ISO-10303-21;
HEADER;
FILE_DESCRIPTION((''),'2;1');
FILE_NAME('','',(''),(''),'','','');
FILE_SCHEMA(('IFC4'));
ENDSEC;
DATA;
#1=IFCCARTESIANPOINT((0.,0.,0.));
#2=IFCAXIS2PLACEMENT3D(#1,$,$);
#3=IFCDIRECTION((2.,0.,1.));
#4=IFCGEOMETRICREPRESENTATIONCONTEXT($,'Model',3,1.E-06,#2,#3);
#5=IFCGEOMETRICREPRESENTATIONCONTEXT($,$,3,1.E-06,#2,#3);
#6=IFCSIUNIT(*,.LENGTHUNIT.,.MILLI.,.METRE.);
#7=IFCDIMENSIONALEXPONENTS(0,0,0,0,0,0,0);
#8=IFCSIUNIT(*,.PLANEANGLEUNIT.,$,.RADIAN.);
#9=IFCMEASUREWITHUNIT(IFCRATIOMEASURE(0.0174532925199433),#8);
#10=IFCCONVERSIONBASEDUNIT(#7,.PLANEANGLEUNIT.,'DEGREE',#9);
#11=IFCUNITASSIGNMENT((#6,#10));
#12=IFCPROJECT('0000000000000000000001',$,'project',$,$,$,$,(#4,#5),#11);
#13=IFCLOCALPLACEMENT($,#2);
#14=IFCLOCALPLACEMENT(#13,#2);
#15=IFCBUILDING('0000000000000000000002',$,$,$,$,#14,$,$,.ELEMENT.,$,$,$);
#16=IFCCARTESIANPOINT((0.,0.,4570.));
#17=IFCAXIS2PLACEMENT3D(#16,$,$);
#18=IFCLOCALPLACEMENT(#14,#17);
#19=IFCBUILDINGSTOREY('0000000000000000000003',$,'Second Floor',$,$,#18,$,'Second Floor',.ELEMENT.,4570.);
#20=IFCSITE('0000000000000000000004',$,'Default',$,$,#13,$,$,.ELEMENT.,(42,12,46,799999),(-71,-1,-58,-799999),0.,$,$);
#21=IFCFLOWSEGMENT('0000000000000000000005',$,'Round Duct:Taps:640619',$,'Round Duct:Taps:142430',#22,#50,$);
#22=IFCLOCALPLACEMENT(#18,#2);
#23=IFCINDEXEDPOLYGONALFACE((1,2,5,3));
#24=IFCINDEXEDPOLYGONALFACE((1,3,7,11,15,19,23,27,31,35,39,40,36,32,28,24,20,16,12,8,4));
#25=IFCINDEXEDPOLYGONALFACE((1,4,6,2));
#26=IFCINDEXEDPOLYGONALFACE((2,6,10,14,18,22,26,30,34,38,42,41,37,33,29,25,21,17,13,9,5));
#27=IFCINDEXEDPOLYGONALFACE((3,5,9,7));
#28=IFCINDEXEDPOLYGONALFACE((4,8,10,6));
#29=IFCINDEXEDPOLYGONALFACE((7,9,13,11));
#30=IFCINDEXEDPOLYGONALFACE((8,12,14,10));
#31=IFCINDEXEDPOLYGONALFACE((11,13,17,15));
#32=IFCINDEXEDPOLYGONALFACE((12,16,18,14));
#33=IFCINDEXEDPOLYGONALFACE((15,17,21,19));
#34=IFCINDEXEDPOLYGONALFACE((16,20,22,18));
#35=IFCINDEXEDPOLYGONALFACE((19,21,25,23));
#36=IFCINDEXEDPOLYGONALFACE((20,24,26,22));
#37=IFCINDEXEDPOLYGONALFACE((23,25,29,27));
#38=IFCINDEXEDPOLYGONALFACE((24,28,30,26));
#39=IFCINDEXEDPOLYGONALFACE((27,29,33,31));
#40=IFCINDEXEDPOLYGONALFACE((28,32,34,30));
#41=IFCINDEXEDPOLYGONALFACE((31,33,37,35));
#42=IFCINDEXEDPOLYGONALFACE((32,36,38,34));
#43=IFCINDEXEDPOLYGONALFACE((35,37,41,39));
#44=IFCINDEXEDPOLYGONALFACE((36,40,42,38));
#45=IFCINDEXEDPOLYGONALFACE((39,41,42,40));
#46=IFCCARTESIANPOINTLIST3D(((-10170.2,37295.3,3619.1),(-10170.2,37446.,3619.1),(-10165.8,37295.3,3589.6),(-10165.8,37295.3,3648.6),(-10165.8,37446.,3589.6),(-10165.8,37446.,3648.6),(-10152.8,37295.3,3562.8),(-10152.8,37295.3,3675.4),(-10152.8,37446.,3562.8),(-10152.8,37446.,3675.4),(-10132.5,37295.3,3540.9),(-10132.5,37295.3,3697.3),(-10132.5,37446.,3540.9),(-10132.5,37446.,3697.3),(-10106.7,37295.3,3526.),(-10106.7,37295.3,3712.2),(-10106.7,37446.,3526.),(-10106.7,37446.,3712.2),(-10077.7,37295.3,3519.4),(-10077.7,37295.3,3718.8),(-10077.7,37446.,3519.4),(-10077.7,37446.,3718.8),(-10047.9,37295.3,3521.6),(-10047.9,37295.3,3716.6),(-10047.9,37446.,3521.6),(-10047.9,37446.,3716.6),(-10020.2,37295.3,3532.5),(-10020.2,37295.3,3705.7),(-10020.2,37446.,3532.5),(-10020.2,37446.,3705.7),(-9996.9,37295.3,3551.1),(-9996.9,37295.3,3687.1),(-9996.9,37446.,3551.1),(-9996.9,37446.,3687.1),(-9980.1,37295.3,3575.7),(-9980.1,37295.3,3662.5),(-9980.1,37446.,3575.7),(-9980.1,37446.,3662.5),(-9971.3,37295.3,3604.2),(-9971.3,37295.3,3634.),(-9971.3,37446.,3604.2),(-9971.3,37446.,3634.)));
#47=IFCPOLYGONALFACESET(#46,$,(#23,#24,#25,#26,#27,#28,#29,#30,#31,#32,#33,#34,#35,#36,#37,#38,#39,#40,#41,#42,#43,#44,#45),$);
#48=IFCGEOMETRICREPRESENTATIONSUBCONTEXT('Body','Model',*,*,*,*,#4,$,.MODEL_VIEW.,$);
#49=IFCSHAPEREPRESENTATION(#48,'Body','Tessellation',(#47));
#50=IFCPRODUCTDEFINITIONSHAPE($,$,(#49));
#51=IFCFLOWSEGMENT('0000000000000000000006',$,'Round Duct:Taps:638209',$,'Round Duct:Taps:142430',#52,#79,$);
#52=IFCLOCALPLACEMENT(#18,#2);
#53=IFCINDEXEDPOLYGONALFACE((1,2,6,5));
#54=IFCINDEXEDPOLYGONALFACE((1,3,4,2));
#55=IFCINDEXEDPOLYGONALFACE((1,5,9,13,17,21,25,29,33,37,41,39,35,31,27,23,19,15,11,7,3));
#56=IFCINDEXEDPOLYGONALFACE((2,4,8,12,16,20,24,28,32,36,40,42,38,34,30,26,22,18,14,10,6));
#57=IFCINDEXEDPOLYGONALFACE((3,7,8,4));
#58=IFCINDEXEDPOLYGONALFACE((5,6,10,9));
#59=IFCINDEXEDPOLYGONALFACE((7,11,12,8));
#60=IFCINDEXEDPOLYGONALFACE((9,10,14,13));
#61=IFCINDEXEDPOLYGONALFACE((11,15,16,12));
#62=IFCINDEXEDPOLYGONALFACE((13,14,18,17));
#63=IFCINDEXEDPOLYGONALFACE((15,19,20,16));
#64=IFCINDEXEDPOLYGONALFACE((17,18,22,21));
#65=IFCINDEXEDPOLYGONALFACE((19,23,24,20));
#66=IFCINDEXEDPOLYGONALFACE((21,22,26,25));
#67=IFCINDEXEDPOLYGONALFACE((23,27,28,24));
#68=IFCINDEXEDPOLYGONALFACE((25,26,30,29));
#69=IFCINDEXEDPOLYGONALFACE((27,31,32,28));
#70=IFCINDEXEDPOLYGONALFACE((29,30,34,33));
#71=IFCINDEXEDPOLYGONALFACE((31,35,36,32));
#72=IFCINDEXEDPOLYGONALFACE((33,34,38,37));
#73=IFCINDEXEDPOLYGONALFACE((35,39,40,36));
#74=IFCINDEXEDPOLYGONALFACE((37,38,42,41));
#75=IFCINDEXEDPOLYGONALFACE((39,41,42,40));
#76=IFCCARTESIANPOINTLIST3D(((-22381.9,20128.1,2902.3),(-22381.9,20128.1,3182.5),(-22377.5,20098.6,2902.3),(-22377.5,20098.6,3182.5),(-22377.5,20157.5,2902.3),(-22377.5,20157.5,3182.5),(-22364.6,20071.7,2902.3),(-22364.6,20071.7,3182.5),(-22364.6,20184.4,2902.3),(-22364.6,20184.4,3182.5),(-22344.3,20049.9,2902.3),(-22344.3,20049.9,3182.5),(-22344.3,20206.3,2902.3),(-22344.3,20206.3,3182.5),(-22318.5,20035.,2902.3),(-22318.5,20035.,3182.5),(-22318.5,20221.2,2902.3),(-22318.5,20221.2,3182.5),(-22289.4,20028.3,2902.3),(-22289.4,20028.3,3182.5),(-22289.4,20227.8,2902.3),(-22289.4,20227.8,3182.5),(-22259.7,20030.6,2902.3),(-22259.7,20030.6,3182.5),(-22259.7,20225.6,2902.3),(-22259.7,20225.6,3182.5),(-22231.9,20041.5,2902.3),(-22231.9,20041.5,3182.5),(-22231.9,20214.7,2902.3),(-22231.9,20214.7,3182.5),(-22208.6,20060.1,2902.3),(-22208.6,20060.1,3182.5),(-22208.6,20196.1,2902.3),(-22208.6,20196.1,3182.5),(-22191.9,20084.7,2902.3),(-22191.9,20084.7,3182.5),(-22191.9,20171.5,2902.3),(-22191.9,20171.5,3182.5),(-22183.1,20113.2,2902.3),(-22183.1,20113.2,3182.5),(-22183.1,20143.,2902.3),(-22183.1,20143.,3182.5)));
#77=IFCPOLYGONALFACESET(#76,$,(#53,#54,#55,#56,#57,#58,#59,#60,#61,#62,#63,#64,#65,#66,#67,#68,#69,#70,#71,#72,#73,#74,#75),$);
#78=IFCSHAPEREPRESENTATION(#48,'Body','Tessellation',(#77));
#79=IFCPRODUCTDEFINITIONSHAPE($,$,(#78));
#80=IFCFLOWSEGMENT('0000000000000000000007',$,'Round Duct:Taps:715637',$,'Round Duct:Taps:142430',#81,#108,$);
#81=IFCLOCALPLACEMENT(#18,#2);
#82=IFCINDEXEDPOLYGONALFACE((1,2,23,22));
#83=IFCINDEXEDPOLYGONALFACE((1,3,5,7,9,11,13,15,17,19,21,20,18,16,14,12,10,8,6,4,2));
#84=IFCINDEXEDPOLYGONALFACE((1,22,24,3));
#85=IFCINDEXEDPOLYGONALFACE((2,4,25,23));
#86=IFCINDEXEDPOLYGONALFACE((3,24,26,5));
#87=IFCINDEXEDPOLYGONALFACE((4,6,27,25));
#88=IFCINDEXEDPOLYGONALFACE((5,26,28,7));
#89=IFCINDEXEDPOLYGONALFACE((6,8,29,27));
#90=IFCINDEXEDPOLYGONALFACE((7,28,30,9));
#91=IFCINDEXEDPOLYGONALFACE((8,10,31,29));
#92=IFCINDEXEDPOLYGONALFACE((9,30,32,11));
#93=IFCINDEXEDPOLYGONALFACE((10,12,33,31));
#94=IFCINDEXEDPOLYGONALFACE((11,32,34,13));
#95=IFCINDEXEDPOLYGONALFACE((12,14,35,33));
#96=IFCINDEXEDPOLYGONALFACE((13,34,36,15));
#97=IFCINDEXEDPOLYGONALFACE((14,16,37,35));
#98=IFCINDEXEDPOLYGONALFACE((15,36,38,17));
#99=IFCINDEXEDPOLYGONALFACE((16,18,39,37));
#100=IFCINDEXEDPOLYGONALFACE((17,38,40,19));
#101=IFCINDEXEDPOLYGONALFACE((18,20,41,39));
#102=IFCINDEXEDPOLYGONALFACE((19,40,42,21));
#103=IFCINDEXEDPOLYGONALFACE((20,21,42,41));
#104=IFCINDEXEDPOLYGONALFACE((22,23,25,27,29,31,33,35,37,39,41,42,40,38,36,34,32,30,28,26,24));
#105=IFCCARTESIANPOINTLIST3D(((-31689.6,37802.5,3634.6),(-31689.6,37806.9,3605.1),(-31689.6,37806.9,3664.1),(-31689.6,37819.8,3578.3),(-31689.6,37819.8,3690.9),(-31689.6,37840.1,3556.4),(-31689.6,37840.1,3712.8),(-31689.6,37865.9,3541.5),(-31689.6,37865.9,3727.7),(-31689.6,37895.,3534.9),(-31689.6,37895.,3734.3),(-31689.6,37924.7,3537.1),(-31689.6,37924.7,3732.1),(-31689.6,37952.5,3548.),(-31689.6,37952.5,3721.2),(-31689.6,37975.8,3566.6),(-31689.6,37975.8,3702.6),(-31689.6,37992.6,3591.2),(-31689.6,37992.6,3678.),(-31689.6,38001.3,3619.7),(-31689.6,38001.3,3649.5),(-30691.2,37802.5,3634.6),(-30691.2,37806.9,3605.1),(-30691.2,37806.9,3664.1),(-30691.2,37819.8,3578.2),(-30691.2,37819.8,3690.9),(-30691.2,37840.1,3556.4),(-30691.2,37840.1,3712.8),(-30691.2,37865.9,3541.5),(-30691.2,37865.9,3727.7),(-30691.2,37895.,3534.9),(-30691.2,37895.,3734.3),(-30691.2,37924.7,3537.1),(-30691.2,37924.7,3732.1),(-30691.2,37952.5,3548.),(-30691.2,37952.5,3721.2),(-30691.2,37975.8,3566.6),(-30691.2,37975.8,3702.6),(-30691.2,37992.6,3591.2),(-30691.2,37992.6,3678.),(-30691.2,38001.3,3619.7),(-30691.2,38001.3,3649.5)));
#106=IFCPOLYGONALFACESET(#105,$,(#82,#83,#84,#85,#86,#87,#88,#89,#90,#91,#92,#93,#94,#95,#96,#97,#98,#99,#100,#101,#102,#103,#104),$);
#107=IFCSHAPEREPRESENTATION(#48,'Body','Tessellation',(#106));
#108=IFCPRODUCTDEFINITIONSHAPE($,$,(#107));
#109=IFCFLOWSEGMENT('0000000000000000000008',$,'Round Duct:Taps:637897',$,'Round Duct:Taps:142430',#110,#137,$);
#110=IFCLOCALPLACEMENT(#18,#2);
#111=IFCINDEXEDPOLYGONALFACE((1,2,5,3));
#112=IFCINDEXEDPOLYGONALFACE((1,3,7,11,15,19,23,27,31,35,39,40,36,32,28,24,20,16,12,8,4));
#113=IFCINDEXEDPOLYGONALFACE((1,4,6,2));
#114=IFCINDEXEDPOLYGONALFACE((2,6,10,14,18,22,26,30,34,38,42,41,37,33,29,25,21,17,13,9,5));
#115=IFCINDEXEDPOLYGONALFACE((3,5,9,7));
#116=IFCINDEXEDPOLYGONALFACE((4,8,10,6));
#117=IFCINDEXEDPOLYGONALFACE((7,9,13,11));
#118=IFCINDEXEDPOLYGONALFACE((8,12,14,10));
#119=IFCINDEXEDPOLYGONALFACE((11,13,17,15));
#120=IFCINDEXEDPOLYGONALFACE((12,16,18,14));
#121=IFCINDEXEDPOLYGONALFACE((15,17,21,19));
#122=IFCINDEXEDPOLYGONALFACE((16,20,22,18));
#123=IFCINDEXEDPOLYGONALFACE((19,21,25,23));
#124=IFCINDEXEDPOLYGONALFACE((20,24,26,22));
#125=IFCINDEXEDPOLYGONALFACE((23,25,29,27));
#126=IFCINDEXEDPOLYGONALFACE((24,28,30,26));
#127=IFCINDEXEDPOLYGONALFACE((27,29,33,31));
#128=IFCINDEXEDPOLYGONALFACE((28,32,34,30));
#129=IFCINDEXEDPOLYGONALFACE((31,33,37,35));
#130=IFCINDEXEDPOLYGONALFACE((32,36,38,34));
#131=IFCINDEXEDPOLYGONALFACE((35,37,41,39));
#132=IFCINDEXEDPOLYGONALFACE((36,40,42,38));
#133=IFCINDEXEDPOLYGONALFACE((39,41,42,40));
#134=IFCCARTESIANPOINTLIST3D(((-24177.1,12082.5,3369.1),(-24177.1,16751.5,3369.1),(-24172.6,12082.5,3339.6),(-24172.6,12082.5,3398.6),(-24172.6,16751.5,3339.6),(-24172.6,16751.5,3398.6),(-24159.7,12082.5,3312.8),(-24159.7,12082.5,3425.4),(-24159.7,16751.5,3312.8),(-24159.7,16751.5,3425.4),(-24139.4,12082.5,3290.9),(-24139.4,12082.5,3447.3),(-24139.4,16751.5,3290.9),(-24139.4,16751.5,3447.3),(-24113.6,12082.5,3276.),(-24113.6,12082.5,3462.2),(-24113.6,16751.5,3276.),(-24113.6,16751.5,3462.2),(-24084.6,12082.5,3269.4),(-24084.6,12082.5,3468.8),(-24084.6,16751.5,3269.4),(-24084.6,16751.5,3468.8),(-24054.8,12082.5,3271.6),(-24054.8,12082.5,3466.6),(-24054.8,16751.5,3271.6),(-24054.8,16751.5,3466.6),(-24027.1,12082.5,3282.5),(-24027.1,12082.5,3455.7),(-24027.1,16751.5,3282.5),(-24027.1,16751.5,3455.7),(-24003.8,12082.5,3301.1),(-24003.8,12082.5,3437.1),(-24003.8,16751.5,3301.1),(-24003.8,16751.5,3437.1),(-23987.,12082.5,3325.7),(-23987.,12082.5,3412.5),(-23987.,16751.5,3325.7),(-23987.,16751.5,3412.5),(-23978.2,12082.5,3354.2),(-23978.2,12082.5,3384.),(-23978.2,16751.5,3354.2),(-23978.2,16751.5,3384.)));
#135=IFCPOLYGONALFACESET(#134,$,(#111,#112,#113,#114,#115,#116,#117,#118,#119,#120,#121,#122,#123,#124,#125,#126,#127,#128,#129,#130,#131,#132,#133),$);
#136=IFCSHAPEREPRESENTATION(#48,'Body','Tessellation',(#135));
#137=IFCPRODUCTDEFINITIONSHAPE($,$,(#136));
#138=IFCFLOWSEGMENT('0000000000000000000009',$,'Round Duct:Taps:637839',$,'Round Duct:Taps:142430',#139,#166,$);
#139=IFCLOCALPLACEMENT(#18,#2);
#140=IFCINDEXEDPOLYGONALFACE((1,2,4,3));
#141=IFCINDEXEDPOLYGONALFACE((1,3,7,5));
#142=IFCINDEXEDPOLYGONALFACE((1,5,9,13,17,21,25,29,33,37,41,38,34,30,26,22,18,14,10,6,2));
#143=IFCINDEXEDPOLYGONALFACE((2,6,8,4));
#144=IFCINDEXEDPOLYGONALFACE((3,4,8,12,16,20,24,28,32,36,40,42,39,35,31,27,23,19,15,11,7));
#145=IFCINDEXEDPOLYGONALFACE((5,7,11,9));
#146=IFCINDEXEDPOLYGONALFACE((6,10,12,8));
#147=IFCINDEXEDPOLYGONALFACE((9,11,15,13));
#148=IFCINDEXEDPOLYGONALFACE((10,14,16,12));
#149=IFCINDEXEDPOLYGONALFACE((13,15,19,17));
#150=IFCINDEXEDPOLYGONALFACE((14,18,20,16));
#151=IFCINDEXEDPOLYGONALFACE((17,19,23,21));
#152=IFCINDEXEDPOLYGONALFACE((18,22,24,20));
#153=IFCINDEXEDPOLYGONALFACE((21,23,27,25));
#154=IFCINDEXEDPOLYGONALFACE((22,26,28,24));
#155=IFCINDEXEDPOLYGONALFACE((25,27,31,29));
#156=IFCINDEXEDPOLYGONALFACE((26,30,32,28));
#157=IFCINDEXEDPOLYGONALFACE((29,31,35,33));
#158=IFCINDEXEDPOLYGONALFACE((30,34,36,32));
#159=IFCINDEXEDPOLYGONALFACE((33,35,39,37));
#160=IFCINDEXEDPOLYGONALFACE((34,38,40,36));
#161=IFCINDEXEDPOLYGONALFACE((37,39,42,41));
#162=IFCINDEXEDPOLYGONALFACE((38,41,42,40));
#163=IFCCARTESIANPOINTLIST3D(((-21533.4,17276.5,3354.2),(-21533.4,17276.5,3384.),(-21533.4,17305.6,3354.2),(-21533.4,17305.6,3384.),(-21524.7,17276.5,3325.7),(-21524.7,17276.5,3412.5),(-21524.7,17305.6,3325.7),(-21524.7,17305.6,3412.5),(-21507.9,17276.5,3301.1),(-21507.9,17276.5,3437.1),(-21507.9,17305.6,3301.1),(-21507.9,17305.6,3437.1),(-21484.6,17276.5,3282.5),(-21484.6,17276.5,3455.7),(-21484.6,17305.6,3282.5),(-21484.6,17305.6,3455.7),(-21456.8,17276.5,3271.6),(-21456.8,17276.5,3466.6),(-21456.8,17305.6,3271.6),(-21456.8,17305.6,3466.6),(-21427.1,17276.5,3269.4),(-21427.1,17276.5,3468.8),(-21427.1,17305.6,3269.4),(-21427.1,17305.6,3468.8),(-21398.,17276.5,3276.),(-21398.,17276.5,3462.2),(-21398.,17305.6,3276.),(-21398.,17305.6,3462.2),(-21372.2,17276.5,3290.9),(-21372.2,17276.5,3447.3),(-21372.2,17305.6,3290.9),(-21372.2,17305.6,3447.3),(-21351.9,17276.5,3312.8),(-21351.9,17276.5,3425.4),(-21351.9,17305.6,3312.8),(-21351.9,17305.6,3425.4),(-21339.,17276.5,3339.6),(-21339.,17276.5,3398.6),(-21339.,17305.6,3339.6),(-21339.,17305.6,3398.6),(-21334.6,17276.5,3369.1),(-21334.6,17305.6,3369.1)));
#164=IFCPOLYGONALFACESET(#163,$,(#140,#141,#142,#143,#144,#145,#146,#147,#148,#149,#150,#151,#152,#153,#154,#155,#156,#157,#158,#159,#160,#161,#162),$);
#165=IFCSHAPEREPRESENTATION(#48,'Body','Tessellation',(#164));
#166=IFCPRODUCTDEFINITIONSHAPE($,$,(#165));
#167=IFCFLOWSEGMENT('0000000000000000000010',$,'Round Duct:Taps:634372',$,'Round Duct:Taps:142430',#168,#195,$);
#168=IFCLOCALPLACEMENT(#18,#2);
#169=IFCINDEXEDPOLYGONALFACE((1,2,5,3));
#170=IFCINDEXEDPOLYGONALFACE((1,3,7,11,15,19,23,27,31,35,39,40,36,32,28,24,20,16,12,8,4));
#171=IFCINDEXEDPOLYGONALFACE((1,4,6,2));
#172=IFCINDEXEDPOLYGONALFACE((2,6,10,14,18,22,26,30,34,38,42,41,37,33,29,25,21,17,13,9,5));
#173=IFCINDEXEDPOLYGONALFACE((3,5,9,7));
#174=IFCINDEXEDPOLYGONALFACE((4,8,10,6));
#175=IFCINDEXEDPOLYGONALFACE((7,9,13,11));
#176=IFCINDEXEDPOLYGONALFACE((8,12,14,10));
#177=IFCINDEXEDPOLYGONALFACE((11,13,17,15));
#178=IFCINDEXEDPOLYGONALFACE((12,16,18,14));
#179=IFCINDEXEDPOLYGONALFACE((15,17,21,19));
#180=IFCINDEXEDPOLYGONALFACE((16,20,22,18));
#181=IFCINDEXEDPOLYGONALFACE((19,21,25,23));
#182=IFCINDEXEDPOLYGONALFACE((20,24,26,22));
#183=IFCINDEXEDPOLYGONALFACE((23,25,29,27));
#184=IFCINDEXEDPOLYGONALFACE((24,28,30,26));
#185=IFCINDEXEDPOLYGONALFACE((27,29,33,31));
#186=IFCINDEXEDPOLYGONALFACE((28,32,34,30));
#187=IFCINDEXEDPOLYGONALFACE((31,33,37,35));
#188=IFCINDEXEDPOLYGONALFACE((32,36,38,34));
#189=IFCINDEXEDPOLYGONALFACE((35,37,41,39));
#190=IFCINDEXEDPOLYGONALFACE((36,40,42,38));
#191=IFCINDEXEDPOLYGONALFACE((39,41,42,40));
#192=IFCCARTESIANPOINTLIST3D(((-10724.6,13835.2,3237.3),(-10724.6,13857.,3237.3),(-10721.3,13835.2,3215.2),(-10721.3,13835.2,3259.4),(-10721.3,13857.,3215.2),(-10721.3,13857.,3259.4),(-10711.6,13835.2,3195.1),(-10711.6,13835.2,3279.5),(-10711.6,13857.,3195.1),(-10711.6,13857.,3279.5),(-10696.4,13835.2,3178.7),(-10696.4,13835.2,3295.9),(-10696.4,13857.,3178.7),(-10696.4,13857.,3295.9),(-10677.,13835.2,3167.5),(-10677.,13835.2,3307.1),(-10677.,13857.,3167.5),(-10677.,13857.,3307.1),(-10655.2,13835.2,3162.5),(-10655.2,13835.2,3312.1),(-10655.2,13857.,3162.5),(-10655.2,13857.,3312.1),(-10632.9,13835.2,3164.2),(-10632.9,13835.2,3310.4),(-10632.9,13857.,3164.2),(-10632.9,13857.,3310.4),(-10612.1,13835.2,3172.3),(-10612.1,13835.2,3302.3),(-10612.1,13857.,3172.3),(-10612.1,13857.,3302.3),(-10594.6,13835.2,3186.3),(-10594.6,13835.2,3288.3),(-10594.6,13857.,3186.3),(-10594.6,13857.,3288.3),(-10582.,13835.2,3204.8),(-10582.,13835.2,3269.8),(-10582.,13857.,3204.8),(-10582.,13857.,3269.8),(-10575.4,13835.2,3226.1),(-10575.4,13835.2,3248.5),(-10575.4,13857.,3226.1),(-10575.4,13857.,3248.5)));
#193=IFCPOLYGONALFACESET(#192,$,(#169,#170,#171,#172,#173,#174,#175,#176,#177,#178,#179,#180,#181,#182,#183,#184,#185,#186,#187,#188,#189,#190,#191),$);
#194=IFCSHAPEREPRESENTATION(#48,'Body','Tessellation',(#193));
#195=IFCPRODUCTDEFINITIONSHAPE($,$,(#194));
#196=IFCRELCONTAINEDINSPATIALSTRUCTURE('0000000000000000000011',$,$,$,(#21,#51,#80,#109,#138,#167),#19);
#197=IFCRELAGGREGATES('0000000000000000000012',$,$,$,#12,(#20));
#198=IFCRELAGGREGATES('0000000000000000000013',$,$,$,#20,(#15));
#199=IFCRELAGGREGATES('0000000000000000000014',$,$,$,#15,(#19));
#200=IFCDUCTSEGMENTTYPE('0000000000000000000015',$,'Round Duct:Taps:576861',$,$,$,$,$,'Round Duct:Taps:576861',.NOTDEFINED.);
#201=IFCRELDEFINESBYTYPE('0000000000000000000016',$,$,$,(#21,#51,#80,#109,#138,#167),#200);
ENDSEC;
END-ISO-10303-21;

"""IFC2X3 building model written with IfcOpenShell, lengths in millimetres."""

from ifc_helpers import new_model, entity, si_unit, converted_unit, direction, frame, frame_2d, origin, origin_2d_with_axis, place, context, subcontext, project, spatial, circle, extrude, type_object, element, save


model = new_model("IFC2X3")

# Units and contexts
model_context = context("Model", 3, precision=1e-06, world=origin(), true_north=direction((2.0, 0.0, 1.0)))
context_of_model = context(None, 3, precision=1e-06, world=origin(), true_north=direction((2.0, 0.0, 1.0)))
body_context = subcontext(model_context, "Body", "Model", "MODEL_VIEW")
ifc_project = project(units=[si_unit("LENGTHUNIT", "METRE", prefix="MILLI"), converted_unit("PLANEANGLEUNIT", "DEGREE", entity("IfcRatioMeasure", 0.0174532925199433), si_unit("PLANEANGLEUNIT", "RADIAN"), dimensions=[0, 0, 0, 0, 0, 0, 0])], contexts=[model_context, context_of_model])

# Site, building, storey
site_placement = place(None, origin())
site = spatial("IfcSite", under=ifc_project, at=site_placement, Name="Default", CompositionType="ELEMENT", RefLatitude=(42, 12, 46, 799999), RefLongitude=(-71, -1, -58, -799999), RefElevation=0.0)
building_placement = place(site_placement, origin())
building = spatial("IfcBuilding", under=site, at=building_placement, CompositionType="ELEMENT")
storey_placement = place(building_placement, frame((0.0, 0.0, 4570.0)))
storey = spatial("IfcBuildingStorey", under=building, at=storey_placement, Name="Second Floor", LongName="Second Floor", CompositionType="ELEMENT", Elevation=4570.0)

# Flow segments
duct_segment_type_1 = type_object("IfcDuctSegmentType", Name="Round Duct:Taps:576861", ElementType="Round Duct:Taps:576861", PredefinedType="NOTDEFINED")
flow_segment_1_placement = place(storey_placement, origin())
element("IfcFlowSegment", 1, at=flow_segment_1_placement, inside=storey, type_object=duct_segment_type_1, Name="Round Duct:Taps:640619", ObjectType="Round Duct:Taps:142430", context=body_context, shape_type="SweptSolid", body=[
    extrude(circle(Radius=100.0, at=frame_2d((0.0, 0.0), x_axis=(1.0, 0.0))), frame((-10070.2, 37295.3, 3619.1), z_axis=(0.0, 1.0, 0.0), x_axis=(-1.0, 0.0, 0.0)), (0.0, 0.0, 1.0), 150.7),
])
flow_segment_2_placement = place(storey_placement, origin())
element("IfcFlowSegment", 2, at=flow_segment_2_placement, inside=storey, type_object=duct_segment_type_1, Name="Round Duct:Taps:638209", ObjectType="Round Duct:Taps:142430", context=body_context, shape_type="SweptSolid", body=[
    extrude(circle(Radius=100.0, at=origin_2d_with_axis()), frame((-22281.9, 20128.1, 2902.3), z_axis=(0.0, 0.0, 1.0), x_axis=(-1.0, 0.0, 0.0)), (0.0, 0.0, 1.0), 280.2),
])
flow_segment_3_placement = place(storey_placement, origin())
element("IfcFlowSegment", 3, at=flow_segment_3_placement, inside=storey, type_object=duct_segment_type_1, Name="Round Duct:Taps:715637", ObjectType="Round Duct:Taps:142430", context=body_context, shape_type="SweptSolid", body=[
    extrude(circle(Radius=100.0, at=frame_2d((0.0, 0.0), x_axis=(1.0, 0.0))), frame((-30691.2, 37902.5, 3634.6), z_axis=(-1.0, 0.0, 0.000023), x_axis=(0.0, -1.0, 0.0)), (0.0, 0.0, 1.0), 998.5),
])
flow_segment_4_placement = place(storey_placement, origin())
element("IfcFlowSegment", 4, at=flow_segment_4_placement, inside=storey, type_object=duct_segment_type_1, Name="Round Duct:Taps:637897", ObjectType="Round Duct:Taps:142430", context=body_context, shape_type="SweptSolid", body=[
    extrude(circle(Radius=100.0, at=frame_2d((0.0, 0.0), x_axis=(1.0, 0.0))), frame((-24077.1, 12082.5, 3369.1), z_axis=(0.0, 1.0, 0.0), x_axis=(-1.0, 0.0, 0.0)), (0.0, 0.0, 1.0), 4669.0),
])
flow_segment_5_placement = place(storey_placement, origin())
element("IfcFlowSegment", 5, at=flow_segment_5_placement, inside=storey, type_object=duct_segment_type_1, Name="Round Duct:Taps:637839", ObjectType="Round Duct:Taps:142430", context=body_context, shape_type="SweptSolid", body=[
    extrude(circle(Radius=100.0, at=origin_2d_with_axis()), frame((-21434.6, 17276.5, 3369.1), z_axis=(0.0, 1.0, 0.0), x_axis=(1.0, 0.0, 0.0)), (0.0, 0.0, 1.0), 29.1),
])
flow_segment_6_placement = place(storey_placement, origin())
element("IfcFlowSegment", 6, at=flow_segment_6_placement, inside=storey, type_object=duct_segment_type_1, Name="Round Duct:Taps:634372", ObjectType="Round Duct:Taps:142430", context=body_context, shape_type="SweptSolid", body=[
    extrude(circle(Radius=75.0, at=frame_2d((0.0, 0.0), x_axis=(1.0, 0.0))), frame((-10649.6, 13835.2, 3237.3), z_axis=(0.0, 1.0, 0.0), x_axis=(-1.0, 0.0, 0.0)), (0.0, 0.0, 1.0), 21.9),
])

save(model, "model.ifc")
